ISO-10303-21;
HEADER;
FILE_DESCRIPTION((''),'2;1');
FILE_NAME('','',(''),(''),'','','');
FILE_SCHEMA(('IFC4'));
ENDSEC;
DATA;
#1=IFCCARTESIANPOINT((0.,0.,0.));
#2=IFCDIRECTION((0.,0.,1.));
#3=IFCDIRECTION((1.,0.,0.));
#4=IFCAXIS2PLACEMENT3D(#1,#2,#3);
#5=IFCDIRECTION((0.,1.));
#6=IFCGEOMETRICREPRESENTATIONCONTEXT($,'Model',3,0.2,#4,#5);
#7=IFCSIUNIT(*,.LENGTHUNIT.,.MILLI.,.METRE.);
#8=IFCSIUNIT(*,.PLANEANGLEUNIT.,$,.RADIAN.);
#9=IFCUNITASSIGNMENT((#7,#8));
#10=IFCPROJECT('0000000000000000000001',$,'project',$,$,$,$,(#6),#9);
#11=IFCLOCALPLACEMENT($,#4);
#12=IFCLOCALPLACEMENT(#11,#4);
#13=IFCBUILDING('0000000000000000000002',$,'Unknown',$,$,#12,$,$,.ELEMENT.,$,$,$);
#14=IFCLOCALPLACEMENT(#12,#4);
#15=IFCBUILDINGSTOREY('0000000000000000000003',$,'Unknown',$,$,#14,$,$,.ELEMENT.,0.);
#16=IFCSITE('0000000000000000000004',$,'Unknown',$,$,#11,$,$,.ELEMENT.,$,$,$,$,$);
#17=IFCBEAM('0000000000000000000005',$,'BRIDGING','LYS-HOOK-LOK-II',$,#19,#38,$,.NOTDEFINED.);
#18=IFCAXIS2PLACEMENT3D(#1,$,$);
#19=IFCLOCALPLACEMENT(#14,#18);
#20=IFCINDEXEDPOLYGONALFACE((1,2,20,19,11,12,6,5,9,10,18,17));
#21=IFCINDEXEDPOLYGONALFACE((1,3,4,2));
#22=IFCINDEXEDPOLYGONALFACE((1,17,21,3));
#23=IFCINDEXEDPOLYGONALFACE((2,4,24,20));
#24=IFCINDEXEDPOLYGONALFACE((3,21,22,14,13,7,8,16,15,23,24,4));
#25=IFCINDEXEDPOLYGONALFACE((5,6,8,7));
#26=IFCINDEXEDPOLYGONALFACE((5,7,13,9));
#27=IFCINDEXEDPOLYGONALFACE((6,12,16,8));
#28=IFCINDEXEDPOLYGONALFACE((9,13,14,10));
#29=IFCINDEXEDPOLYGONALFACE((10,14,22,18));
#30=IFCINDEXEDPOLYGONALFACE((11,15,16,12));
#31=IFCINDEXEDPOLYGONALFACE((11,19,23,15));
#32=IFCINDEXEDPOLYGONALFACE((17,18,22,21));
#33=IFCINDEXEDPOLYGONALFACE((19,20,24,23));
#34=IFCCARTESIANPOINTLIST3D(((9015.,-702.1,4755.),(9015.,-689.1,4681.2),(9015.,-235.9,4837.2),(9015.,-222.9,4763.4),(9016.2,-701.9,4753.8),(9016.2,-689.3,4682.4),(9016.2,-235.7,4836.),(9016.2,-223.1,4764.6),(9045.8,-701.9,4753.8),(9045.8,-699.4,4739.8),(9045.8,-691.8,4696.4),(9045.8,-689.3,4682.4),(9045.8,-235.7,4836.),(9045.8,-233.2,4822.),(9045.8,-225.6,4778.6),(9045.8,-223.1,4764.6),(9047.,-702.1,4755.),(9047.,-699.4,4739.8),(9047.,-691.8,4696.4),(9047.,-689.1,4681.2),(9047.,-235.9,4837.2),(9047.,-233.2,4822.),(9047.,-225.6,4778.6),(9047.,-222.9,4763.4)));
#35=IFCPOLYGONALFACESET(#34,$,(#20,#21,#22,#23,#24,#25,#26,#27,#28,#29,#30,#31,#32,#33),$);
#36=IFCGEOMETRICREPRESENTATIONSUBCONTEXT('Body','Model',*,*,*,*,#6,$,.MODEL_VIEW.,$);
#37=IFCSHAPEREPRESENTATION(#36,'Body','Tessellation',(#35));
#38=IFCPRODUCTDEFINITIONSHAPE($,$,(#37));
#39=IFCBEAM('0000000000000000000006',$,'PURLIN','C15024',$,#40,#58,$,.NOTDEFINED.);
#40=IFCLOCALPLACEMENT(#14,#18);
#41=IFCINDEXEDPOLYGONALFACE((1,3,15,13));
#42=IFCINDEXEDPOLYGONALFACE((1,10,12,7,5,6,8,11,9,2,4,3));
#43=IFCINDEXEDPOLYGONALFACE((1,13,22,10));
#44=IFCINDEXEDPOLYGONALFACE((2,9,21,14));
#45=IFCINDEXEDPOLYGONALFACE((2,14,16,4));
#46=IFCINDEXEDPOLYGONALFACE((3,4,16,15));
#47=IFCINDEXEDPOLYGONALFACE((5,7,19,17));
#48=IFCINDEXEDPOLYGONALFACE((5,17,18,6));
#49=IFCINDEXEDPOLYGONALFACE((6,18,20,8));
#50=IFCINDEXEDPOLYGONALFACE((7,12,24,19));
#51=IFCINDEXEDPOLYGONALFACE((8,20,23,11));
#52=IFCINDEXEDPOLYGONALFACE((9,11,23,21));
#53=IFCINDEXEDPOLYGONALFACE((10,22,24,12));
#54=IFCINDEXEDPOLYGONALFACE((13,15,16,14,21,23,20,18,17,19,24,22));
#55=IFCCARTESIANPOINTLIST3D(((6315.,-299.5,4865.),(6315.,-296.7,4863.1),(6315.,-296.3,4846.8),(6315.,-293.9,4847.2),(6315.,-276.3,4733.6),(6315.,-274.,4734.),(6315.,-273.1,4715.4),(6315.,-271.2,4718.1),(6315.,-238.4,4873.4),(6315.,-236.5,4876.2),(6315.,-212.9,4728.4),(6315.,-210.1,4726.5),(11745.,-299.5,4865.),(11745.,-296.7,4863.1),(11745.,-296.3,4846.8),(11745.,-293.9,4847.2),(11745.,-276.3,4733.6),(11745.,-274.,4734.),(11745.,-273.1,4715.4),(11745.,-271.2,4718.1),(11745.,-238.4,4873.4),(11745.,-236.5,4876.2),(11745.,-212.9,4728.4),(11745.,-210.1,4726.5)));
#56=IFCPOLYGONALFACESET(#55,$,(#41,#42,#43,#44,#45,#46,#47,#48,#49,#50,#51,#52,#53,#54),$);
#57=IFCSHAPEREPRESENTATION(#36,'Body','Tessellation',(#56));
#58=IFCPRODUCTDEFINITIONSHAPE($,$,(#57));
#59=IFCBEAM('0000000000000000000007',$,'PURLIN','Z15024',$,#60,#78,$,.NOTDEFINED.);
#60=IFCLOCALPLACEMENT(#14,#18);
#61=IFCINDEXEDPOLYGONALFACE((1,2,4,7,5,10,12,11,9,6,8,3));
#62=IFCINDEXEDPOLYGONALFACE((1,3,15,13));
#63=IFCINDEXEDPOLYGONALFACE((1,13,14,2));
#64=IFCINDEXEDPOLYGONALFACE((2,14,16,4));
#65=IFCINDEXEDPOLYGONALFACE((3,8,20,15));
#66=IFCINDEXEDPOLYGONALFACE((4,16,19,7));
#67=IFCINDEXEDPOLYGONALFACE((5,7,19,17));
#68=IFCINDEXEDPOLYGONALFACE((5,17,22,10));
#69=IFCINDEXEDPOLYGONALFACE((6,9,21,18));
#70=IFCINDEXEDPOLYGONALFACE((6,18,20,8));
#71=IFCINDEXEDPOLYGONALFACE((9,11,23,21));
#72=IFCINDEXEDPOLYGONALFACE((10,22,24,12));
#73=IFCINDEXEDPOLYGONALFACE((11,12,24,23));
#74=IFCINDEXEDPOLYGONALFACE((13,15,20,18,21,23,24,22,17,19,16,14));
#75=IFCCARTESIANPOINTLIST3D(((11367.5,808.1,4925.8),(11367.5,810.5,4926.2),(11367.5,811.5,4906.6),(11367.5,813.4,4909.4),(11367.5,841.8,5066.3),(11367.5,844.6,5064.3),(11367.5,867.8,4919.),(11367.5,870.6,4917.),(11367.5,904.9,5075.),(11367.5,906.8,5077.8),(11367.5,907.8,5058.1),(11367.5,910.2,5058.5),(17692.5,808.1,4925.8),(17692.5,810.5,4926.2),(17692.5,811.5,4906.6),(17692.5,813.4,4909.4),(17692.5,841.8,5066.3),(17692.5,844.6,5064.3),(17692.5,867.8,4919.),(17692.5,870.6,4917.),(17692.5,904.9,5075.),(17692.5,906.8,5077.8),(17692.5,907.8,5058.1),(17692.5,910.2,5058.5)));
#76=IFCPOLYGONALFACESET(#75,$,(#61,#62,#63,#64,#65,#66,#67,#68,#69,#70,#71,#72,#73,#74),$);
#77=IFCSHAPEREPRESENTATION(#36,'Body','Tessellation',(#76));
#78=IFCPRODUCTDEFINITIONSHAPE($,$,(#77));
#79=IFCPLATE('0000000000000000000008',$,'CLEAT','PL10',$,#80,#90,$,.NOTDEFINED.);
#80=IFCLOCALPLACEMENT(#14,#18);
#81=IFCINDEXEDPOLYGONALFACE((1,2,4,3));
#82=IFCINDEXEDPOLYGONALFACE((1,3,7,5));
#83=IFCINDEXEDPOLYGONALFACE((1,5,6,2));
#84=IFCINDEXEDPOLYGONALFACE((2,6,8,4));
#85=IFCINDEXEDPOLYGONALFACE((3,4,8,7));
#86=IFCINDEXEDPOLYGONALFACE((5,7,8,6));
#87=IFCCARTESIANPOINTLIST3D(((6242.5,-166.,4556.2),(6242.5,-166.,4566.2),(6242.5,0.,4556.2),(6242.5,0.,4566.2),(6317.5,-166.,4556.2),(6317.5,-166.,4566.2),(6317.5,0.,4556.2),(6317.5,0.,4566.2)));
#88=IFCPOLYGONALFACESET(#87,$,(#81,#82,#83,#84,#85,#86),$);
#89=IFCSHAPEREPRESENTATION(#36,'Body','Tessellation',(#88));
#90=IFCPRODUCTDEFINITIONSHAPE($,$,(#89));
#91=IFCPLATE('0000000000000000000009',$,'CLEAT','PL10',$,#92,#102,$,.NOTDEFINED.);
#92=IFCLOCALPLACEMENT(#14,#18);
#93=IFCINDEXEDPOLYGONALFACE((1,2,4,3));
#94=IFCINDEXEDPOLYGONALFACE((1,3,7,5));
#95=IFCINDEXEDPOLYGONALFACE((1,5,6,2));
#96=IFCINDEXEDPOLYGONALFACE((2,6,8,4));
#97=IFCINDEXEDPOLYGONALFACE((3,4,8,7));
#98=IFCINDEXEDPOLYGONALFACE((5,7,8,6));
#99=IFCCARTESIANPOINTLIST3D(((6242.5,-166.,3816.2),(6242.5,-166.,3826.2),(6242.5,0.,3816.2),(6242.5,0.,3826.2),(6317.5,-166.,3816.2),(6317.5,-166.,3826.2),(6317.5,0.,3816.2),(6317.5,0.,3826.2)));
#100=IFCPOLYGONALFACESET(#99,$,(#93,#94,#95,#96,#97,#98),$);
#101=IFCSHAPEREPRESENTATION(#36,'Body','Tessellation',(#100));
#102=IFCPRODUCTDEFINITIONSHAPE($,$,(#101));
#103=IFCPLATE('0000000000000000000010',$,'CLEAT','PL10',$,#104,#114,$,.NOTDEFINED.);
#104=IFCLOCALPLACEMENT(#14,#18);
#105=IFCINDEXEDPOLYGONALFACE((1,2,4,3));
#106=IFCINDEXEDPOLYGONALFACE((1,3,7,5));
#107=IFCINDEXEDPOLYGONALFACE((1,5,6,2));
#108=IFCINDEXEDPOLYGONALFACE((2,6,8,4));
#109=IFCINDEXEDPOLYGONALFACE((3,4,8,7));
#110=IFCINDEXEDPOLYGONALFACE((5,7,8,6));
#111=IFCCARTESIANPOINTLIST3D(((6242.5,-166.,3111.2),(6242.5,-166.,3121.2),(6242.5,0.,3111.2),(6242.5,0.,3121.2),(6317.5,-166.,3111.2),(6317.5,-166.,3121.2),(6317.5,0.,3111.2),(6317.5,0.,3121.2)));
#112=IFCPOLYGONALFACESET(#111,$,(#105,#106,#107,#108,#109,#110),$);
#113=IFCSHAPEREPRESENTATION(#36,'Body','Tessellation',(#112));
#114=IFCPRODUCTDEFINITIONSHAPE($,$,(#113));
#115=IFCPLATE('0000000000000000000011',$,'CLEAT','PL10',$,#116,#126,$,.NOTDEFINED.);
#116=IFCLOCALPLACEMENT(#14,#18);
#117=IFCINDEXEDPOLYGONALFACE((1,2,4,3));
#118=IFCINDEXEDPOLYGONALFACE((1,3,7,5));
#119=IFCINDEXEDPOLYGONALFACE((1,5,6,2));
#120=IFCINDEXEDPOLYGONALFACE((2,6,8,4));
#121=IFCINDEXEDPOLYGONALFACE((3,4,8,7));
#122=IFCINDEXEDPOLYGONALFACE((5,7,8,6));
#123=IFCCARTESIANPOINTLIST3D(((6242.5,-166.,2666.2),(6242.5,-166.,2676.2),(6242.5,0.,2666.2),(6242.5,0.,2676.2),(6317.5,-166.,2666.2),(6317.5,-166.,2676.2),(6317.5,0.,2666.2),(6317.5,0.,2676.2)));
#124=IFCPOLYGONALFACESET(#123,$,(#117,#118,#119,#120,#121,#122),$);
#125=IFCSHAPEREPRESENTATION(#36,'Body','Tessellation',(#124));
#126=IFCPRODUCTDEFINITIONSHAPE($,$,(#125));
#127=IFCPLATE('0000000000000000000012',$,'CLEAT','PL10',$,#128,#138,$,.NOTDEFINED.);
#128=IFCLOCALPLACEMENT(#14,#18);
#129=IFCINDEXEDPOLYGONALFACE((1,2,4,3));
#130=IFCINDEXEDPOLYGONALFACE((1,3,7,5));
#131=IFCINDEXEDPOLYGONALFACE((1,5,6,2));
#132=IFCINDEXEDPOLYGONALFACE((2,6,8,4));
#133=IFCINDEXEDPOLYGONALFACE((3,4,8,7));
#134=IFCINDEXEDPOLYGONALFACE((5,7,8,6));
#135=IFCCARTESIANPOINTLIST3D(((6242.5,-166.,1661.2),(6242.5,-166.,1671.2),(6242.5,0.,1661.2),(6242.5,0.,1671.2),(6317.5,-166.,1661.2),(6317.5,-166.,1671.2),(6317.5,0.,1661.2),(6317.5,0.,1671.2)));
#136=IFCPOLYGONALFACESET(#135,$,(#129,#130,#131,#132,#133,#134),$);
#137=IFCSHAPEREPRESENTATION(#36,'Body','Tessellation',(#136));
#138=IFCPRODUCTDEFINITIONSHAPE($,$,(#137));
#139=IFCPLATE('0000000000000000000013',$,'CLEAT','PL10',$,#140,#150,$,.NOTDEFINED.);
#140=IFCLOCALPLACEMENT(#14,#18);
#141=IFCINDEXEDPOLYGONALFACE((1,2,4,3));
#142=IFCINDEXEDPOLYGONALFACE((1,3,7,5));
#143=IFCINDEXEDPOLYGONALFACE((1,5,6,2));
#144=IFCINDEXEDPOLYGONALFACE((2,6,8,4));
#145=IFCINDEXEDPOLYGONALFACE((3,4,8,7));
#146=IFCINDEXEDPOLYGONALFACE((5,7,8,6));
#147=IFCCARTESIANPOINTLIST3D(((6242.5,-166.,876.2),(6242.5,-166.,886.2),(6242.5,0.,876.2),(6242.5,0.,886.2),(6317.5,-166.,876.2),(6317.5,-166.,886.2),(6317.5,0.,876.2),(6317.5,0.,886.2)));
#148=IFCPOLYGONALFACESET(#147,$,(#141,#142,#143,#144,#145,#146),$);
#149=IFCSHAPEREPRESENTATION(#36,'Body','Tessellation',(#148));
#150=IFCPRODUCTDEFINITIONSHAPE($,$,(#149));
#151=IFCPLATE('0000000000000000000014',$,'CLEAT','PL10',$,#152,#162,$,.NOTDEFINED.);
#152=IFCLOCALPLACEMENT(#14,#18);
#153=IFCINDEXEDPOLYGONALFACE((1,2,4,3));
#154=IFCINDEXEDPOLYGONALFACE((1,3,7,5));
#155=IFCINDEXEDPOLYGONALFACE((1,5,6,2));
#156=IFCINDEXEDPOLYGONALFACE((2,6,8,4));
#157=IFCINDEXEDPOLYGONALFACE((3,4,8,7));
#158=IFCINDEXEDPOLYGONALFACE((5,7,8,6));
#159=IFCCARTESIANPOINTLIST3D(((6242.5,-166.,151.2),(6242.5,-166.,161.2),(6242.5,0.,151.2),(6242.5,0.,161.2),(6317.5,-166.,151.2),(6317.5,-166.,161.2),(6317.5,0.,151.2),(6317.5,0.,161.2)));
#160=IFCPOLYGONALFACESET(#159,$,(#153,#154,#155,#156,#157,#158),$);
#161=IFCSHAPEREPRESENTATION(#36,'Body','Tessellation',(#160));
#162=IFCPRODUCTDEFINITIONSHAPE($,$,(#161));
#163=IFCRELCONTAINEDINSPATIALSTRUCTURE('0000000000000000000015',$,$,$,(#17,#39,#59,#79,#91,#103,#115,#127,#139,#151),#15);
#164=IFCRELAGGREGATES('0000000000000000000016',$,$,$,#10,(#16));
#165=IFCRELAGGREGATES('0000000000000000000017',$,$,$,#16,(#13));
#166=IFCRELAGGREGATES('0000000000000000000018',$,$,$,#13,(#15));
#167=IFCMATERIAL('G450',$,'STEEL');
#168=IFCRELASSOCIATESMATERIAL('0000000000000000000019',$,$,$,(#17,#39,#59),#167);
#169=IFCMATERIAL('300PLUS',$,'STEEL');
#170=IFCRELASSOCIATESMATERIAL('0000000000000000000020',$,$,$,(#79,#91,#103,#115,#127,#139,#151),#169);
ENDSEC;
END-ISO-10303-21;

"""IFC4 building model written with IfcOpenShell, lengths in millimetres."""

from ifc_helpers import new_model, si_unit, direction, frame, origin_with_axes, place, context, subcontext, project, spatial, line, indexed_curve, outline, extrude, material, element, save


model = new_model("IFC4")

# Units and contexts
model_context = context("Model", 3, precision=0.2, world=origin_with_axes(), true_north=direction((0.0, 1.0)))
body_context = subcontext(model_context, "Body", "Model", "MODEL_VIEW")
ifc_project = project(units=[si_unit("LENGTHUNIT", "METRE", prefix="MILLI"), si_unit("PLANEANGLEUNIT", "RADIAN")], contexts=[model_context])

# Site, building, storey
site_placement = place(None, origin_with_axes())
site = spatial("IfcSite", under=ifc_project, at=site_placement, Name="Unknown", CompositionType="ELEMENT")
building_placement = place(site_placement, origin_with_axes())
building = spatial("IfcBuilding", under=site, at=building_placement, Name="Unknown", CompositionType="ELEMENT")
storey_placement = place(building_placement, origin_with_axes())
storey = spatial("IfcBuildingStorey", under=building, at=storey_placement, Name="Unknown", CompositionType="ELEMENT", Elevation=0.0)

# Shared definitions
ifc_material_1 = material(Name="G450", Category="STEEL")

# Shared definitions
ifc_material_2 = material(Name="300PLUS", Category="STEEL")

# Beams
beam_1_placement = place(storey_placement, frame((9031.0, -695.6, 4718.1), z_axis=(1.0, 0.0, 0.0), x_axis=(0.0, 0.984809, 0.173641)))
element("IfcBeam", 1, at=beam_1_placement, inside=storey, material=ifc_material_1, Name="BRIDGING", Description="LYS-HOOK-LOK-II", PredefinedType="NOTDEFINED", context=body_context, shape_type="SolidModel", body=[
    extrude(outline(indexed_curve([(16.0, -37.5), (16.0, -22.0), (14.8, -22.0), (14.8, -36.3), (-14.8, -36.3), (-14.8, 36.3), (14.8, 36.3), (14.8, 22.0), (16.0, 22.0), (16.0, 37.5), (-16.0, 37.5), (-16.0, -37.5)], segments=[line(1, 2, 3, 4, 5, 6, 7, 8, 9, 10, 11, 12, 1)])), frame((0.0, 0.0, 0.0), z_axis=(-1.0, 0.0, 0.0), x_axis=(0.0, 0.0, 1.0)), (0.0, 0.0, -1.0), 473.4),
])
beam_2_placement = place(storey_placement, frame((6315.0, -254.8, 4795.8), z_axis=(0.0, -0.984808, -0.173648), x_axis=(1.0, 0.0, 0.0)))
element("IfcBeam", 2, at=beam_2_placement, inside=storey, material=ifc_material_1, Name="PURLIN", Description="C15024", PredefinedType="NOTDEFINED", context=body_context, shape_type="SolidModel", body=[
    extrude(outline(indexed_curve([(32.0, -76.0), (32.0, -57.5), (29.6, -57.5), (29.6, -73.6), (-29.6, -73.6), (-29.6, 73.6), (29.6, 73.6), (29.6, 57.5), (32.0, 57.5), (32.0, 76.0), (-32.0, 76.0), (-32.0, -76.0)], segments=[line(1, 2, 3, 4, 5, 6, 7, 8, 9, 10, 11, 12, 1)])), frame((0.0, 0.0, 0.0), z_axis=(-1.0, 0.0, 0.0), x_axis=(0.0, 0.0, 1.0)), (0.0, 0.0, -1.0), 5430.0),
])
beam_3_placement = place(storey_placement, frame((11367.5, 856.2, 4991.7), z_axis=(0.0, -0.984808, -0.173648), x_axis=(1.0, 0.0, 0.0)))
element("IfcBeam", 3, at=beam_3_placement, inside=storey, material=ifc_material_1, Name="PURLIN", Description="Z15024", PredefinedType="NOTDEFINED", context=body_context, shape_type="SolidModel", body=[
    extrude(outline(indexed_curve([(58.8, -76.0), (58.8, -56.5), (56.4, -56.5), (56.4, -73.6), (1.2, -73.6), (1.2, 76.0), (-64.8, 76.0), (-64.8, 56.5), (-62.4, 56.5), (-62.4, 73.6), (-1.2, 73.6), (-1.2, -76.0)], segments=[line(1, 2, 3, 4, 5, 6, 7, 8, 9, 10, 11, 12, 1)])), frame((0.0, 0.0, 0.0), z_axis=(-1.0, 0.0, 0.0), x_axis=(0.0, 0.0, 1.0)), (0.0, 0.0, -1.0), 6325.0),
])

# Plates
for number, where, z_axis, x_axis, name in (
    (4, (6317.5, 0.0, 4561.2), (0.0, 0.0, 1.0), (-1.0, 0.0, 0.0), "CLEAT"),
    (5, (6317.5, 0.0, 3821.2), (0.0, 0.0, 1.0), (-1.0, 0.0, 0.0), "CLEAT"),
    (6, (6317.5, 0.0, 3116.2), (0.0, 0.0, 1.0), (-1.0, 0.0, 0.0), "CLEAT"),
    (7, (6317.5, 0.0, 2671.2), (0.0, 0.0, 1.0), (-1.0, 0.0, 0.0), "CLEAT"),
    (8, (6317.5, 0.0, 1666.2), (0.0, 0.0, 1.0), (-1.0, 0.0, 0.0), "CLEAT"),
    (9, (6317.5, 0.0, 881.2), (0.0, 0.0, 1.0), (-1.0, 0.0, 0.0), "CLEAT"),
    (10, (6317.5, 0.0, 156.2), (0.0, 0.0, 1.0), (-1.0, 0.0, 0.0), "CLEAT"),
):
    element("IfcPlate", number, at=place(storey_placement, frame(where, z_axis=z_axis, x_axis=x_axis)), inside=storey, material=ifc_material_2, Name=name, Description="PL10", PredefinedType="NOTDEFINED", context=body_context, shape_type="SolidModel", body=[
        extrude(outline(indexed_curve([(0.0, 0.0), (75.0, 0.0), (75.0, 166.0), (0.0, 166.0)], segments=[line(1, 2, 3, 4, 1)])), frame((0.0, 0.0, 5.0), z_axis=(0.0, 0.0, 1.0), x_axis=(1.0, 0.0, 0.0)), (0.0, 0.0, -1.0), 10.0),
    ])

save(model, "model.ifc")
